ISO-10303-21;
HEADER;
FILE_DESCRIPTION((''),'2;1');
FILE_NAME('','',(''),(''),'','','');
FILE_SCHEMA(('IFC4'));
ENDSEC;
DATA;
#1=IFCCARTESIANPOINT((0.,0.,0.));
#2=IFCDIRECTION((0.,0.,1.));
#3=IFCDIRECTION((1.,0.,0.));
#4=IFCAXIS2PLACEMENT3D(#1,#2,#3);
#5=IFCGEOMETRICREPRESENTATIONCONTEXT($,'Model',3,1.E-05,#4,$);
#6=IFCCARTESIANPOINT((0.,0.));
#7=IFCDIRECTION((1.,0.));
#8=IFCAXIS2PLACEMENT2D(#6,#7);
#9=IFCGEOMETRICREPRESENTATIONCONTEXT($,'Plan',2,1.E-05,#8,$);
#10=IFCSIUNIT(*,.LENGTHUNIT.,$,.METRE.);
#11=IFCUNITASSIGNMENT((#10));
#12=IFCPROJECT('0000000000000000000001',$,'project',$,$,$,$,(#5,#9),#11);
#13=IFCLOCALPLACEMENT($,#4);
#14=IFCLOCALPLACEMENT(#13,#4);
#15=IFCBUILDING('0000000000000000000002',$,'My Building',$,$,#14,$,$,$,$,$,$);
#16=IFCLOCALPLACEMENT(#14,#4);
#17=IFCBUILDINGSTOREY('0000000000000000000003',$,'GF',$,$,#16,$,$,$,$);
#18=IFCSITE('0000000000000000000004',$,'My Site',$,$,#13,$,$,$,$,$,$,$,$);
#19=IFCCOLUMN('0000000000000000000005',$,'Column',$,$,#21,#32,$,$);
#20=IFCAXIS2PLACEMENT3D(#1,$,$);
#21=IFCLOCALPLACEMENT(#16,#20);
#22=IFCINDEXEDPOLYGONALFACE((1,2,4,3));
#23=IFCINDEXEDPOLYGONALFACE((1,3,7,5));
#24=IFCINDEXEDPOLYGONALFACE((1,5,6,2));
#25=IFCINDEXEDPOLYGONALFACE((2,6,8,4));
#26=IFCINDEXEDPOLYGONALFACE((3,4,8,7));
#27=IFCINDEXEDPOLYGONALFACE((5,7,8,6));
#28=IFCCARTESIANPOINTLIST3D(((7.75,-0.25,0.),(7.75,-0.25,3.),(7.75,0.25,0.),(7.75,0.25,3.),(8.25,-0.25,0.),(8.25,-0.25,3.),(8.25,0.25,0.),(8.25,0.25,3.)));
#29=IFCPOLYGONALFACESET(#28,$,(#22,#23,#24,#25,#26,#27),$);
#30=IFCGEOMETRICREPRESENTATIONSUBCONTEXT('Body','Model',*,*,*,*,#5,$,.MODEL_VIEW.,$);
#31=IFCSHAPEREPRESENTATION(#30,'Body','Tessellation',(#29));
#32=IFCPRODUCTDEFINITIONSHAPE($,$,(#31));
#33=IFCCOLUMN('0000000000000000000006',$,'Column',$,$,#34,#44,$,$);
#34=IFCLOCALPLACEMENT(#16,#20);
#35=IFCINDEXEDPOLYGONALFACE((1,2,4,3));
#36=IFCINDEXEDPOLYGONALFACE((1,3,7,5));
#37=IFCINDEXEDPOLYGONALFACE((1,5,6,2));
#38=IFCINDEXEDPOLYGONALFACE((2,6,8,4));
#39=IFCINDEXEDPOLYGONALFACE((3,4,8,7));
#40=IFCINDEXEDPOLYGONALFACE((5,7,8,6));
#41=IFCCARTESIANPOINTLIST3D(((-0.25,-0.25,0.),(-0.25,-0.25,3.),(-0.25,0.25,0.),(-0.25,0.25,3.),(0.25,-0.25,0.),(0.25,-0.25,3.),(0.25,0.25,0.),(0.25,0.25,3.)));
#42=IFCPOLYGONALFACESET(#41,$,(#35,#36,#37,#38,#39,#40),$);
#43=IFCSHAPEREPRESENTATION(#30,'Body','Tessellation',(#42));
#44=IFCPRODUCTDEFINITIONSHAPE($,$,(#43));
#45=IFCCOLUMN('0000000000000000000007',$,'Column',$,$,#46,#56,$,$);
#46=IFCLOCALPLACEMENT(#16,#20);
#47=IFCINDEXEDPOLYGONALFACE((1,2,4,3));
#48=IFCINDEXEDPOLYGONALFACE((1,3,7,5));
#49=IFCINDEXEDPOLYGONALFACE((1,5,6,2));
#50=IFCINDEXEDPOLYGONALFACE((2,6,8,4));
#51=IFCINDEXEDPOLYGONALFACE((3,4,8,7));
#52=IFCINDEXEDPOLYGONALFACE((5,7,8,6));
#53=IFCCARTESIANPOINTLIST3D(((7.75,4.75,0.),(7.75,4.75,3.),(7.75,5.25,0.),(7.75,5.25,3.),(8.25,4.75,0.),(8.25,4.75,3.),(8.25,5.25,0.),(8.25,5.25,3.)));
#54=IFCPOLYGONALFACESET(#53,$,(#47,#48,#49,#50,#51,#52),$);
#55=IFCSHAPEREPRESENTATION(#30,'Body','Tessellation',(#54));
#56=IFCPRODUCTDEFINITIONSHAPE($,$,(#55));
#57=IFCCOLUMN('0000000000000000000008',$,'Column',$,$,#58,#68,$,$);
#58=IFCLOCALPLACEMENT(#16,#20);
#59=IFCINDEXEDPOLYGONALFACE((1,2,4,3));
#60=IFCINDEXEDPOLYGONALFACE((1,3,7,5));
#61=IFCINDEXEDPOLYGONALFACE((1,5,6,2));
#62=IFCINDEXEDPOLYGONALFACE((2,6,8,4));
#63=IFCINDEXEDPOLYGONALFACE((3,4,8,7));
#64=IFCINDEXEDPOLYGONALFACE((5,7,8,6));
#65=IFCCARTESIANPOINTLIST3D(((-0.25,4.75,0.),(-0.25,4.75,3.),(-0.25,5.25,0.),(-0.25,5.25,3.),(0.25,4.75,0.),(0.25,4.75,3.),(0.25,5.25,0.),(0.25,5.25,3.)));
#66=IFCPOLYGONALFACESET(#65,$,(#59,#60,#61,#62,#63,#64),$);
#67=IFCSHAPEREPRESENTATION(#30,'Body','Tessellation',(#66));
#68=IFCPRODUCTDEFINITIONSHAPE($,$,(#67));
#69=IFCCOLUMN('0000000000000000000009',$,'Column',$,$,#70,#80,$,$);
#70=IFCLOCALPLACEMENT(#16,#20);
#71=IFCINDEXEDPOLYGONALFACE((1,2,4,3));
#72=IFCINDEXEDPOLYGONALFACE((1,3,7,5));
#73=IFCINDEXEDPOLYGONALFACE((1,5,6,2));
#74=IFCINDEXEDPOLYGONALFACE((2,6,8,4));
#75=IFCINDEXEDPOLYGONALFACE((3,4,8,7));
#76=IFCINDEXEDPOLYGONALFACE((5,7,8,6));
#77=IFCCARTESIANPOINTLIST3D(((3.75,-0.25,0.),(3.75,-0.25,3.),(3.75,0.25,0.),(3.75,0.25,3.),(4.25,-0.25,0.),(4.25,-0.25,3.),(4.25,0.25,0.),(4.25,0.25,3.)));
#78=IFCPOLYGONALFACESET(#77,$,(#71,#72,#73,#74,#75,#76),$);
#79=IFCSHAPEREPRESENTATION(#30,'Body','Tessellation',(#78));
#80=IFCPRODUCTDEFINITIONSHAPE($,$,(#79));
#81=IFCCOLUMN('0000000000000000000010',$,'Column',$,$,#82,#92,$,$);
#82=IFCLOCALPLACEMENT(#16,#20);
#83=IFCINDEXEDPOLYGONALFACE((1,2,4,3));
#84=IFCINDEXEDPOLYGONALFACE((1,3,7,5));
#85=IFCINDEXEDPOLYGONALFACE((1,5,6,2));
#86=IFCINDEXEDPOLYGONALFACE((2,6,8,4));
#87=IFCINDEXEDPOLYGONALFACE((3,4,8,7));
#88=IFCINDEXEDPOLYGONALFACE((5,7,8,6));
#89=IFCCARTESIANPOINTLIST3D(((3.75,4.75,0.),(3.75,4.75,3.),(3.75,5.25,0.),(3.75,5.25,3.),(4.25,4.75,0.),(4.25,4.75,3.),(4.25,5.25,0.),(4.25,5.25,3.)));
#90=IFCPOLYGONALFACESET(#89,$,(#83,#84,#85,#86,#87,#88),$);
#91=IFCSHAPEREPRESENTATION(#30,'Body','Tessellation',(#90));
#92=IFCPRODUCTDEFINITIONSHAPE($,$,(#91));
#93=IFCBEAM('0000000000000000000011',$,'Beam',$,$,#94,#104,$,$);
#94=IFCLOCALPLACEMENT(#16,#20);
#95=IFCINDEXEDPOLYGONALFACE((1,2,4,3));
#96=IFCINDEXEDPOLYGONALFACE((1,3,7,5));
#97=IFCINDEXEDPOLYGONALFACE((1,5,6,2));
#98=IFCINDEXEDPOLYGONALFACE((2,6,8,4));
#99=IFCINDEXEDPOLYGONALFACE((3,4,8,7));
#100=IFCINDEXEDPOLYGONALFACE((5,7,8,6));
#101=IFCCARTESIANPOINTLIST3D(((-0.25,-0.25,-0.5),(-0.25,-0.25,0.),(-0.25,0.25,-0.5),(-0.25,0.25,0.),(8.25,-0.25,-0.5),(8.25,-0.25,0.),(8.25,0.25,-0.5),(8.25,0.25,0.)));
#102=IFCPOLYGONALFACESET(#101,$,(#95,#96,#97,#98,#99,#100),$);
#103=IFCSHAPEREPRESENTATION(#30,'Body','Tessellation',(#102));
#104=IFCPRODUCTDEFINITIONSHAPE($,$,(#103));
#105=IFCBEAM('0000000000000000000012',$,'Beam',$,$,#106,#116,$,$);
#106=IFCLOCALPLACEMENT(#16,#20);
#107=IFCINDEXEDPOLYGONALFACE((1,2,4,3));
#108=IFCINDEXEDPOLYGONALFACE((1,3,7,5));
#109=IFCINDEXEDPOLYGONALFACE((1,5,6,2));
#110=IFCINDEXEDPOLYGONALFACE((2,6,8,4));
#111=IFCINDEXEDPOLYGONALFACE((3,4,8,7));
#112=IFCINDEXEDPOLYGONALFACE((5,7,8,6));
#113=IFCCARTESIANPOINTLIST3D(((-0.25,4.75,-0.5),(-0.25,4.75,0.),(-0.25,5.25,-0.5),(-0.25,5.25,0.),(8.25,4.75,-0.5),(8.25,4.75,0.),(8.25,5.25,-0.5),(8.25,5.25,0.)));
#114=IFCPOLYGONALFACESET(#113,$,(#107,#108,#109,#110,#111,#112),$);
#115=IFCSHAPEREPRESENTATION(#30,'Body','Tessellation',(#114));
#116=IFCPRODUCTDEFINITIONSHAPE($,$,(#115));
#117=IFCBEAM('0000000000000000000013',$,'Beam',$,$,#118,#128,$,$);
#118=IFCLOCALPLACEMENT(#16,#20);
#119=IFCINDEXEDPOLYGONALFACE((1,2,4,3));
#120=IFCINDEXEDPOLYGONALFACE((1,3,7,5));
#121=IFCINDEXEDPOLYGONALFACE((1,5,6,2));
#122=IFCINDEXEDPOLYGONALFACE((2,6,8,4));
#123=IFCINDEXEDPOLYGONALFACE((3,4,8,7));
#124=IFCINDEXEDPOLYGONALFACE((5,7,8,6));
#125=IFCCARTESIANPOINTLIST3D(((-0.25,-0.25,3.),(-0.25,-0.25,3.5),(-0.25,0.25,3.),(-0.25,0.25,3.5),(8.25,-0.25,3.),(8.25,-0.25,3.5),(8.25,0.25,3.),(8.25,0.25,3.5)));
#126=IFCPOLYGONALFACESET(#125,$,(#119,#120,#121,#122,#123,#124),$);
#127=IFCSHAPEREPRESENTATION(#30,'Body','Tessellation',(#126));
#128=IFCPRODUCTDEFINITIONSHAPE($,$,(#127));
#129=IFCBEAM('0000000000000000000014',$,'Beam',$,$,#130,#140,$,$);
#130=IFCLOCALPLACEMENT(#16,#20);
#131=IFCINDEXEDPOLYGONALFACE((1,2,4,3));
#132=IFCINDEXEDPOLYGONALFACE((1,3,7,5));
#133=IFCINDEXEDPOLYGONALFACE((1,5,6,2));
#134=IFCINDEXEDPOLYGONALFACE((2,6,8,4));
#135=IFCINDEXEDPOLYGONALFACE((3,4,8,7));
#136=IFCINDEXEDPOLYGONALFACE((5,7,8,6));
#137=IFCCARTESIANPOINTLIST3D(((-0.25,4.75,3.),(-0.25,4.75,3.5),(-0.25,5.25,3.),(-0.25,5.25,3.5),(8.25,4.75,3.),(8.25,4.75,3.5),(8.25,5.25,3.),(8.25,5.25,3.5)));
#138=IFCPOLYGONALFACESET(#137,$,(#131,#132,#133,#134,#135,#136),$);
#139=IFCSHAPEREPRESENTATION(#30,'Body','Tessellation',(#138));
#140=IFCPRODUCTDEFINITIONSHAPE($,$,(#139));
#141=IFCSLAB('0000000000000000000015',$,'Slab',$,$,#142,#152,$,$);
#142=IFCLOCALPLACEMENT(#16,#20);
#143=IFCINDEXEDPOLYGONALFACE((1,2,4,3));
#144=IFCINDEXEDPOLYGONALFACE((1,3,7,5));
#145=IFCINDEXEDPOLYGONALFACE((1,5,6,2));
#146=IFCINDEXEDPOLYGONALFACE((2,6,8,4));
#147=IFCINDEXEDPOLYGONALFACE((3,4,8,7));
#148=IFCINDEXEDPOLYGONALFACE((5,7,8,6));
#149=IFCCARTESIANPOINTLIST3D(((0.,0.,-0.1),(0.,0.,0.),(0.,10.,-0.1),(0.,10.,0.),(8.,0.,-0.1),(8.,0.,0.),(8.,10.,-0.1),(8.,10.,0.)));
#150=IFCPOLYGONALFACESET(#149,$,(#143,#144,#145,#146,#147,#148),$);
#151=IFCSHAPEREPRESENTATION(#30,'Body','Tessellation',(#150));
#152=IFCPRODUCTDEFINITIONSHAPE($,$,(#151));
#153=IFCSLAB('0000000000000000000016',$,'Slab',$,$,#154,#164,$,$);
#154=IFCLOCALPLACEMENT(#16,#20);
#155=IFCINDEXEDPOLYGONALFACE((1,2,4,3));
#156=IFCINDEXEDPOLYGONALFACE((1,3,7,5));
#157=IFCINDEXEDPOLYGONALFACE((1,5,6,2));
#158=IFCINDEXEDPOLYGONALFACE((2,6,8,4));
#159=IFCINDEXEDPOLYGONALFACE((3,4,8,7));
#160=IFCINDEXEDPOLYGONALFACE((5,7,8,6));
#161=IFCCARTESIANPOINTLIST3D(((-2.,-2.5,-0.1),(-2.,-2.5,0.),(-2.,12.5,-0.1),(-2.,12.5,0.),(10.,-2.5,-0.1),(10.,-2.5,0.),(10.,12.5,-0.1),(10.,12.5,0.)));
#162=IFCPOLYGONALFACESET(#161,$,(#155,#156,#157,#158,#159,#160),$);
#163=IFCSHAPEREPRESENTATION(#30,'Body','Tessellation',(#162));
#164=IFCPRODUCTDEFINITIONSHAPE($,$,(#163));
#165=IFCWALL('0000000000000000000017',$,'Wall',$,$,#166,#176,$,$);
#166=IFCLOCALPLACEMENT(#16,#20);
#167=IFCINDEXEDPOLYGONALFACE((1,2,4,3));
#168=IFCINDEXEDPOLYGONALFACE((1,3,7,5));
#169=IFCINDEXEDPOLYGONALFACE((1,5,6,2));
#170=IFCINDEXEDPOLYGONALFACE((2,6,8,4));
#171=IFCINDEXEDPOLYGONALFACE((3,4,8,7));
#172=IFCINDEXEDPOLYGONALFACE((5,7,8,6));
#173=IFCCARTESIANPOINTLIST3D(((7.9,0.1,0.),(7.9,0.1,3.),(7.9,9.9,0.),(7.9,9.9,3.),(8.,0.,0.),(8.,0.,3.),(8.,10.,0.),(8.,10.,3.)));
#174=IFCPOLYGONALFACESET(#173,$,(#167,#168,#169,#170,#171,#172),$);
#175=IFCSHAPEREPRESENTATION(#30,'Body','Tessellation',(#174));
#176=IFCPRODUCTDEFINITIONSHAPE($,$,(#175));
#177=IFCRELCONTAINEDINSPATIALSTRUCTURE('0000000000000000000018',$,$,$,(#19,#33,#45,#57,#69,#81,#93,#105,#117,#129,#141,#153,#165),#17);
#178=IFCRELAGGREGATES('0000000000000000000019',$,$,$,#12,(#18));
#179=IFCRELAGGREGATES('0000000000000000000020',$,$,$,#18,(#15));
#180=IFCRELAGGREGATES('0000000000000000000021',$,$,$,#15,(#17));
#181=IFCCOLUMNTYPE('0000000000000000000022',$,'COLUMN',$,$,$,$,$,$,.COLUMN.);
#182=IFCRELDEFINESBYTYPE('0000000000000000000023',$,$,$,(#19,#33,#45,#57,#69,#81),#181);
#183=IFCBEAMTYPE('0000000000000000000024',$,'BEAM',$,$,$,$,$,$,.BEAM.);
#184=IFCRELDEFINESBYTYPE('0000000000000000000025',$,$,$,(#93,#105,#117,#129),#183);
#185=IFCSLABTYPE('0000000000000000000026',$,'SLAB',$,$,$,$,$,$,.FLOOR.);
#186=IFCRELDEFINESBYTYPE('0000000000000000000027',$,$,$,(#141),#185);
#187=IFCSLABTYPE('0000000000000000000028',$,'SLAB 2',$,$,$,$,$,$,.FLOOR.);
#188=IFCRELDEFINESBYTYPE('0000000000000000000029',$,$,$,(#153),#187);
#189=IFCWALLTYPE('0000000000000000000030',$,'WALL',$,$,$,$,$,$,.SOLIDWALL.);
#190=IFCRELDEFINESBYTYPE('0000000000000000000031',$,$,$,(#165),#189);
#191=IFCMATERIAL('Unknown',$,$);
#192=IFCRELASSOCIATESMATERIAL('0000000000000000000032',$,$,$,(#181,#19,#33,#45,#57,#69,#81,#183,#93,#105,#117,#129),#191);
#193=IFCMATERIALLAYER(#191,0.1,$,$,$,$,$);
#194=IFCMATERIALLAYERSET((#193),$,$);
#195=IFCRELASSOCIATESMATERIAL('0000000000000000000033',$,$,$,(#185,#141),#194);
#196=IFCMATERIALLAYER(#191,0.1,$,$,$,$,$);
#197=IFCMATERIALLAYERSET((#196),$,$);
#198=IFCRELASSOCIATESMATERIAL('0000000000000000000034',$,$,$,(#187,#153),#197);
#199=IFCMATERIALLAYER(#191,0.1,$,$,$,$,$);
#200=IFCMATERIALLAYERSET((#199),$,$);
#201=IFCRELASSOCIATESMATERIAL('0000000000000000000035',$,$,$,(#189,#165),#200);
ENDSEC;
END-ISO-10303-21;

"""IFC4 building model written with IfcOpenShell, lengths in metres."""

from ifc_helpers import new_model, si_unit, frame, origin_with_axes, origin_2d_with_axis, place, context, subcontext, project, spatial, line, indexed_curve, rectangle, outline, extrude, material, layer, layer_set, layer_usage, material_profile, profile_set, profile_usage, type_object, element, save


model = new_model("IFC4")

# Units and contexts
model_context = context("Model", 3, precision=1e-05, world=origin_with_axes())
plan_context = context("Plan", 2, precision=1e-05, world=origin_2d_with_axis())
body_context_1 = subcontext(model_context, "Body", "Model", "MODEL_VIEW")
ifc_project = project(units=[si_unit("LENGTHUNIT", "METRE")], contexts=[model_context, plan_context])

# Site, building, storey
site_placement = place(None, origin_with_axes())
site = spatial("IfcSite", under=ifc_project, at=site_placement, Name="My Site")
building_placement = place(site_placement, origin_with_axes())
building = spatial("IfcBuilding", under=site, at=building_placement, Name="My Building")
storey_placement = place(building_placement, origin_with_axes())
storey = spatial("IfcBuildingStorey", under=building, at=storey_placement, Name="GF")

# Columns
ifc_material = material(Name="Unknown")
ifc_material_profile_1 = material_profile(ifc_material, rectangle(XDim=0.5, YDim=0.5))
ifc_profile_set_1 = profile_set([ifc_material_profile_1])
ifc_profile_usage_1 = profile_usage(ifc_profile_set_1, cardinal=5)
column_type = type_object("IfcColumnType", Name="COLUMN", PredefinedType="COLUMN", material=ifc_profile_set_1)
column_1_placement = place(storey_placement, frame((8.0, 0.0, 0.0), z_axis=(0.0, 0.0, 1.0), x_axis=(1.0, 0.0, 0.0)))
element("IfcColumn", 1, at=column_1_placement, inside=storey, type_object=column_type, material=ifc_profile_usage_1, Name="Column", context=body_context_1, shape_type="SweptSolid", body=[
    extrude(rectangle(XDim=0.5, YDim=0.5), origin_with_axes(), (0.0, 0.0, 1.0), 3.0),
])
ifc_profile_usage_2 = profile_usage(ifc_profile_set_1, cardinal=5)
column_2_placement = place(storey_placement, origin_with_axes())
element("IfcColumn", 2, at=column_2_placement, inside=storey, type_object=column_type, material=ifc_profile_usage_2, Name="Column", context=body_context_1, shape_type="SweptSolid", body=[
    extrude(rectangle(XDim=0.5, YDim=0.5), origin_with_axes(), (0.0, 0.0, 1.0), 3.0),
])
ifc_profile_usage_3 = profile_usage(ifc_profile_set_1, cardinal=5)
column_3_placement = place(storey_placement, frame((8.0, 5.0, 0.0), z_axis=(0.0, 0.0, 1.0), x_axis=(1.0, 0.0, 0.0)))
element("IfcColumn", 3, at=column_3_placement, inside=storey, type_object=column_type, material=ifc_profile_usage_3, Name="Column", context=body_context_1, shape_type="SweptSolid", body=[
    extrude(rectangle(XDim=0.5, YDim=0.5), origin_with_axes(), (0.0, 0.0, 1.0), 3.0),
])
ifc_profile_usage_4 = profile_usage(ifc_profile_set_1, cardinal=5)
column_4_placement = place(storey_placement, frame((0.0, 5.0, 0.0), z_axis=(0.0, 0.0, 1.0), x_axis=(1.0, 0.0, 0.0)))
element("IfcColumn", 4, at=column_4_placement, inside=storey, type_object=column_type, material=ifc_profile_usage_4, Name="Column", context=body_context_1, shape_type="SweptSolid", body=[
    extrude(rectangle(XDim=0.5, YDim=0.5), origin_with_axes(), (0.0, 0.0, 1.0), 3.0),
])
ifc_profile_usage_5 = profile_usage(ifc_profile_set_1, cardinal=5)
column_5_placement = place(storey_placement, frame((4.0, 0.0, 0.0), z_axis=(0.0, 0.0, 1.0), x_axis=(1.0, 0.0, 0.0)))
element("IfcColumn", 5, at=column_5_placement, inside=storey, type_object=column_type, material=ifc_profile_usage_5, Name="Column", context=body_context_1, shape_type="SweptSolid", body=[
    extrude(rectangle(XDim=0.5, YDim=0.5), origin_with_axes(), (0.0, 0.0, 1.0), 3.0),
])
ifc_profile_usage_6 = profile_usage(ifc_profile_set_1, cardinal=5)
column_6_placement = place(storey_placement, frame((4.0, 5.0, 0.0), z_axis=(0.0, 0.0, 1.0), x_axis=(1.0, 0.0, 0.0)))
element("IfcColumn", 6, at=column_6_placement, inside=storey, type_object=column_type, material=ifc_profile_usage_6, Name="Column", context=body_context_1, shape_type="SweptSolid", body=[
    extrude(rectangle(XDim=0.5, YDim=0.5), origin_with_axes(), (0.0, 0.0, 1.0), 3.0),
])

# Beams
ifc_material_profile_2 = material_profile(ifc_material, rectangle(XDim=0.5, YDim=0.5))
ifc_profile_set_2 = profile_set([ifc_material_profile_2])
ifc_profile_usage_7 = profile_usage(ifc_profile_set_2, cardinal=5)
beam_type = type_object("IfcBeamType", Name="BEAM", PredefinedType="BEAM", material=ifc_profile_set_2)
beam_1_placement = place(storey_placement, frame((-0.25, 0.0, -0.25), z_axis=(1.0, 0.0, 0.0), x_axis=(0.0, 1.0, 0.0)))
element("IfcBeam", 7, at=beam_1_placement, inside=storey, type_object=beam_type, material=ifc_profile_usage_7, Name="Beam", context=body_context_1, shape_type="SweptSolid", body=[
    extrude(rectangle(XDim=0.5, YDim=0.5), origin_with_axes(), (0.0, 0.0, 1.0), 8.5),
])
ifc_profile_usage_8 = profile_usage(ifc_profile_set_2, cardinal=5)
beam_2_placement = place(storey_placement, frame((-0.25, 5.0, -0.25), z_axis=(1.0, 0.0, 0.0), x_axis=(0.0, 1.0, 0.0)))
element("IfcBeam", 8, at=beam_2_placement, inside=storey, type_object=beam_type, material=ifc_profile_usage_8, Name="Beam", context=body_context_1, shape_type="SweptSolid", body=[
    extrude(rectangle(XDim=0.5, YDim=0.5), origin_with_axes(), (0.0, 0.0, 1.0), 8.5),
])
ifc_profile_usage_9 = profile_usage(ifc_profile_set_2, cardinal=5)
beam_3_placement = place(storey_placement, frame((-0.25, 0.0, 3.25), z_axis=(1.0, 0.0, 0.0), x_axis=(0.0, 1.0, 0.0)))
element("IfcBeam", 9, at=beam_3_placement, inside=storey, type_object=beam_type, material=ifc_profile_usage_9, Name="Beam", context=body_context_1, shape_type="SweptSolid", body=[
    extrude(rectangle(XDim=0.5, YDim=0.5), origin_with_axes(), (0.0, 0.0, 1.0), 8.5),
])
ifc_profile_usage_10 = profile_usage(ifc_profile_set_2, cardinal=5)
beam_4_placement = place(storey_placement, frame((-0.25, 5.0, 3.25), z_axis=(1.0, 0.0, 0.0), x_axis=(0.0, 1.0, 0.0)))
element("IfcBeam", 10, at=beam_4_placement, inside=storey, type_object=beam_type, material=ifc_profile_usage_10, Name="Beam", context=body_context_1, shape_type="SweptSolid", body=[
    extrude(rectangle(XDim=0.5, YDim=0.5), origin_with_axes(), (0.0, 0.0, 1.0), 8.5),
])

# Slabs
ifc_layer_1 = layer(ifc_material, 0.1)
ifc_layer_set_1 = layer_set([ifc_layer_1])
ifc_layer_usage_1 = layer_usage(ifc_layer_set_1, "AXIS3", "POSITIVE", -0.1)
slab_type_1 = type_object("IfcSlabType", Name="SLAB", PredefinedType="FLOOR", material=ifc_layer_set_1)
slab_1_placement = place(storey_placement, origin_with_axes())
element("IfcSlab", 11, at=slab_1_placement, inside=storey, type_object=slab_type_1, material=ifc_layer_usage_1, Name="Slab", context=body_context_1, shape_type="SweptSolid", body=[
    extrude(outline(indexed_curve([(0.0, 0.0), (0.0, 10.0), (8.0, 10.0), (8.0, 0.0), (0.0, 0.0)])), frame((0.0, 0.0, -0.1), z_axis=(0.0, 0.0, 1.0), x_axis=(1.0, 0.0, 0.0)), (0.0, 0.0, 1.0), 0.1),
])
ifc_layer_2 = layer(ifc_material, 0.1)
ifc_layer_set_2 = layer_set([ifc_layer_2])
ifc_layer_usage_2 = layer_usage(ifc_layer_set_2, "AXIS3", "POSITIVE", -0.1)
slab_type_2 = type_object("IfcSlabType", Name="SLAB 2", PredefinedType="FLOOR", material=ifc_layer_set_2)
slab_2_placement = place(storey_placement, frame((-2.0, -2.5, 0.0), z_axis=(0.0, 0.0, 1.0), x_axis=(1.0, 0.0, 0.0)))
element("IfcSlab", 12, at=slab_2_placement, inside=storey, type_object=slab_type_2, material=ifc_layer_usage_2, Name="Slab", context=body_context_1, shape_type="SweptSolid", body=[
    extrude(outline(indexed_curve([(0.0, 0.0), (12.0, 0.0), (12.0, 15.0), (0.0, 15.0), (0.0, 0.0)])), frame((0.0, 0.0, -0.1), z_axis=(0.0, 0.0, 1.0), x_axis=(1.0, 0.0, 0.0)), (0.0, 0.0, 1.0), 0.1),
])

# Shared definitions
ifc_layer_3 = layer(ifc_material, 0.1)
ifc_layer_set_3 = layer_set([ifc_layer_3])
wall_type_1 = type_object("IfcWallType", Name="WALL", PredefinedType="SOLIDWALL", material=ifc_layer_set_3)

# Wall
ifc_layer_usage_3 = layer_usage(ifc_layer_set_3, "AXIS2", "POSITIVE", 0.0)
wall_1_placement = place(storey_placement, frame((8.0, 0.0, 0.0), z_axis=(0.0, 0.0, 1.0), x_axis=(0.0, 1.0, 0.0)))
element("IfcWall", 13, at=wall_1_placement, inside=storey, type_object=wall_type_1, material=ifc_layer_usage_3, Name="Wall", context=body_context_1, shape_type="SweptSolid", body=[
    extrude(outline(indexed_curve([(0.0, 0.0), (0.1, 0.1), (9.9, 0.1), (10.0, 0.0)], segments=[line(1, 2, 3, 4, 1)])), origin_with_axes(), (0.0, 0.0, 1.0), 3.0),
])

save(model, "model.ifc")
